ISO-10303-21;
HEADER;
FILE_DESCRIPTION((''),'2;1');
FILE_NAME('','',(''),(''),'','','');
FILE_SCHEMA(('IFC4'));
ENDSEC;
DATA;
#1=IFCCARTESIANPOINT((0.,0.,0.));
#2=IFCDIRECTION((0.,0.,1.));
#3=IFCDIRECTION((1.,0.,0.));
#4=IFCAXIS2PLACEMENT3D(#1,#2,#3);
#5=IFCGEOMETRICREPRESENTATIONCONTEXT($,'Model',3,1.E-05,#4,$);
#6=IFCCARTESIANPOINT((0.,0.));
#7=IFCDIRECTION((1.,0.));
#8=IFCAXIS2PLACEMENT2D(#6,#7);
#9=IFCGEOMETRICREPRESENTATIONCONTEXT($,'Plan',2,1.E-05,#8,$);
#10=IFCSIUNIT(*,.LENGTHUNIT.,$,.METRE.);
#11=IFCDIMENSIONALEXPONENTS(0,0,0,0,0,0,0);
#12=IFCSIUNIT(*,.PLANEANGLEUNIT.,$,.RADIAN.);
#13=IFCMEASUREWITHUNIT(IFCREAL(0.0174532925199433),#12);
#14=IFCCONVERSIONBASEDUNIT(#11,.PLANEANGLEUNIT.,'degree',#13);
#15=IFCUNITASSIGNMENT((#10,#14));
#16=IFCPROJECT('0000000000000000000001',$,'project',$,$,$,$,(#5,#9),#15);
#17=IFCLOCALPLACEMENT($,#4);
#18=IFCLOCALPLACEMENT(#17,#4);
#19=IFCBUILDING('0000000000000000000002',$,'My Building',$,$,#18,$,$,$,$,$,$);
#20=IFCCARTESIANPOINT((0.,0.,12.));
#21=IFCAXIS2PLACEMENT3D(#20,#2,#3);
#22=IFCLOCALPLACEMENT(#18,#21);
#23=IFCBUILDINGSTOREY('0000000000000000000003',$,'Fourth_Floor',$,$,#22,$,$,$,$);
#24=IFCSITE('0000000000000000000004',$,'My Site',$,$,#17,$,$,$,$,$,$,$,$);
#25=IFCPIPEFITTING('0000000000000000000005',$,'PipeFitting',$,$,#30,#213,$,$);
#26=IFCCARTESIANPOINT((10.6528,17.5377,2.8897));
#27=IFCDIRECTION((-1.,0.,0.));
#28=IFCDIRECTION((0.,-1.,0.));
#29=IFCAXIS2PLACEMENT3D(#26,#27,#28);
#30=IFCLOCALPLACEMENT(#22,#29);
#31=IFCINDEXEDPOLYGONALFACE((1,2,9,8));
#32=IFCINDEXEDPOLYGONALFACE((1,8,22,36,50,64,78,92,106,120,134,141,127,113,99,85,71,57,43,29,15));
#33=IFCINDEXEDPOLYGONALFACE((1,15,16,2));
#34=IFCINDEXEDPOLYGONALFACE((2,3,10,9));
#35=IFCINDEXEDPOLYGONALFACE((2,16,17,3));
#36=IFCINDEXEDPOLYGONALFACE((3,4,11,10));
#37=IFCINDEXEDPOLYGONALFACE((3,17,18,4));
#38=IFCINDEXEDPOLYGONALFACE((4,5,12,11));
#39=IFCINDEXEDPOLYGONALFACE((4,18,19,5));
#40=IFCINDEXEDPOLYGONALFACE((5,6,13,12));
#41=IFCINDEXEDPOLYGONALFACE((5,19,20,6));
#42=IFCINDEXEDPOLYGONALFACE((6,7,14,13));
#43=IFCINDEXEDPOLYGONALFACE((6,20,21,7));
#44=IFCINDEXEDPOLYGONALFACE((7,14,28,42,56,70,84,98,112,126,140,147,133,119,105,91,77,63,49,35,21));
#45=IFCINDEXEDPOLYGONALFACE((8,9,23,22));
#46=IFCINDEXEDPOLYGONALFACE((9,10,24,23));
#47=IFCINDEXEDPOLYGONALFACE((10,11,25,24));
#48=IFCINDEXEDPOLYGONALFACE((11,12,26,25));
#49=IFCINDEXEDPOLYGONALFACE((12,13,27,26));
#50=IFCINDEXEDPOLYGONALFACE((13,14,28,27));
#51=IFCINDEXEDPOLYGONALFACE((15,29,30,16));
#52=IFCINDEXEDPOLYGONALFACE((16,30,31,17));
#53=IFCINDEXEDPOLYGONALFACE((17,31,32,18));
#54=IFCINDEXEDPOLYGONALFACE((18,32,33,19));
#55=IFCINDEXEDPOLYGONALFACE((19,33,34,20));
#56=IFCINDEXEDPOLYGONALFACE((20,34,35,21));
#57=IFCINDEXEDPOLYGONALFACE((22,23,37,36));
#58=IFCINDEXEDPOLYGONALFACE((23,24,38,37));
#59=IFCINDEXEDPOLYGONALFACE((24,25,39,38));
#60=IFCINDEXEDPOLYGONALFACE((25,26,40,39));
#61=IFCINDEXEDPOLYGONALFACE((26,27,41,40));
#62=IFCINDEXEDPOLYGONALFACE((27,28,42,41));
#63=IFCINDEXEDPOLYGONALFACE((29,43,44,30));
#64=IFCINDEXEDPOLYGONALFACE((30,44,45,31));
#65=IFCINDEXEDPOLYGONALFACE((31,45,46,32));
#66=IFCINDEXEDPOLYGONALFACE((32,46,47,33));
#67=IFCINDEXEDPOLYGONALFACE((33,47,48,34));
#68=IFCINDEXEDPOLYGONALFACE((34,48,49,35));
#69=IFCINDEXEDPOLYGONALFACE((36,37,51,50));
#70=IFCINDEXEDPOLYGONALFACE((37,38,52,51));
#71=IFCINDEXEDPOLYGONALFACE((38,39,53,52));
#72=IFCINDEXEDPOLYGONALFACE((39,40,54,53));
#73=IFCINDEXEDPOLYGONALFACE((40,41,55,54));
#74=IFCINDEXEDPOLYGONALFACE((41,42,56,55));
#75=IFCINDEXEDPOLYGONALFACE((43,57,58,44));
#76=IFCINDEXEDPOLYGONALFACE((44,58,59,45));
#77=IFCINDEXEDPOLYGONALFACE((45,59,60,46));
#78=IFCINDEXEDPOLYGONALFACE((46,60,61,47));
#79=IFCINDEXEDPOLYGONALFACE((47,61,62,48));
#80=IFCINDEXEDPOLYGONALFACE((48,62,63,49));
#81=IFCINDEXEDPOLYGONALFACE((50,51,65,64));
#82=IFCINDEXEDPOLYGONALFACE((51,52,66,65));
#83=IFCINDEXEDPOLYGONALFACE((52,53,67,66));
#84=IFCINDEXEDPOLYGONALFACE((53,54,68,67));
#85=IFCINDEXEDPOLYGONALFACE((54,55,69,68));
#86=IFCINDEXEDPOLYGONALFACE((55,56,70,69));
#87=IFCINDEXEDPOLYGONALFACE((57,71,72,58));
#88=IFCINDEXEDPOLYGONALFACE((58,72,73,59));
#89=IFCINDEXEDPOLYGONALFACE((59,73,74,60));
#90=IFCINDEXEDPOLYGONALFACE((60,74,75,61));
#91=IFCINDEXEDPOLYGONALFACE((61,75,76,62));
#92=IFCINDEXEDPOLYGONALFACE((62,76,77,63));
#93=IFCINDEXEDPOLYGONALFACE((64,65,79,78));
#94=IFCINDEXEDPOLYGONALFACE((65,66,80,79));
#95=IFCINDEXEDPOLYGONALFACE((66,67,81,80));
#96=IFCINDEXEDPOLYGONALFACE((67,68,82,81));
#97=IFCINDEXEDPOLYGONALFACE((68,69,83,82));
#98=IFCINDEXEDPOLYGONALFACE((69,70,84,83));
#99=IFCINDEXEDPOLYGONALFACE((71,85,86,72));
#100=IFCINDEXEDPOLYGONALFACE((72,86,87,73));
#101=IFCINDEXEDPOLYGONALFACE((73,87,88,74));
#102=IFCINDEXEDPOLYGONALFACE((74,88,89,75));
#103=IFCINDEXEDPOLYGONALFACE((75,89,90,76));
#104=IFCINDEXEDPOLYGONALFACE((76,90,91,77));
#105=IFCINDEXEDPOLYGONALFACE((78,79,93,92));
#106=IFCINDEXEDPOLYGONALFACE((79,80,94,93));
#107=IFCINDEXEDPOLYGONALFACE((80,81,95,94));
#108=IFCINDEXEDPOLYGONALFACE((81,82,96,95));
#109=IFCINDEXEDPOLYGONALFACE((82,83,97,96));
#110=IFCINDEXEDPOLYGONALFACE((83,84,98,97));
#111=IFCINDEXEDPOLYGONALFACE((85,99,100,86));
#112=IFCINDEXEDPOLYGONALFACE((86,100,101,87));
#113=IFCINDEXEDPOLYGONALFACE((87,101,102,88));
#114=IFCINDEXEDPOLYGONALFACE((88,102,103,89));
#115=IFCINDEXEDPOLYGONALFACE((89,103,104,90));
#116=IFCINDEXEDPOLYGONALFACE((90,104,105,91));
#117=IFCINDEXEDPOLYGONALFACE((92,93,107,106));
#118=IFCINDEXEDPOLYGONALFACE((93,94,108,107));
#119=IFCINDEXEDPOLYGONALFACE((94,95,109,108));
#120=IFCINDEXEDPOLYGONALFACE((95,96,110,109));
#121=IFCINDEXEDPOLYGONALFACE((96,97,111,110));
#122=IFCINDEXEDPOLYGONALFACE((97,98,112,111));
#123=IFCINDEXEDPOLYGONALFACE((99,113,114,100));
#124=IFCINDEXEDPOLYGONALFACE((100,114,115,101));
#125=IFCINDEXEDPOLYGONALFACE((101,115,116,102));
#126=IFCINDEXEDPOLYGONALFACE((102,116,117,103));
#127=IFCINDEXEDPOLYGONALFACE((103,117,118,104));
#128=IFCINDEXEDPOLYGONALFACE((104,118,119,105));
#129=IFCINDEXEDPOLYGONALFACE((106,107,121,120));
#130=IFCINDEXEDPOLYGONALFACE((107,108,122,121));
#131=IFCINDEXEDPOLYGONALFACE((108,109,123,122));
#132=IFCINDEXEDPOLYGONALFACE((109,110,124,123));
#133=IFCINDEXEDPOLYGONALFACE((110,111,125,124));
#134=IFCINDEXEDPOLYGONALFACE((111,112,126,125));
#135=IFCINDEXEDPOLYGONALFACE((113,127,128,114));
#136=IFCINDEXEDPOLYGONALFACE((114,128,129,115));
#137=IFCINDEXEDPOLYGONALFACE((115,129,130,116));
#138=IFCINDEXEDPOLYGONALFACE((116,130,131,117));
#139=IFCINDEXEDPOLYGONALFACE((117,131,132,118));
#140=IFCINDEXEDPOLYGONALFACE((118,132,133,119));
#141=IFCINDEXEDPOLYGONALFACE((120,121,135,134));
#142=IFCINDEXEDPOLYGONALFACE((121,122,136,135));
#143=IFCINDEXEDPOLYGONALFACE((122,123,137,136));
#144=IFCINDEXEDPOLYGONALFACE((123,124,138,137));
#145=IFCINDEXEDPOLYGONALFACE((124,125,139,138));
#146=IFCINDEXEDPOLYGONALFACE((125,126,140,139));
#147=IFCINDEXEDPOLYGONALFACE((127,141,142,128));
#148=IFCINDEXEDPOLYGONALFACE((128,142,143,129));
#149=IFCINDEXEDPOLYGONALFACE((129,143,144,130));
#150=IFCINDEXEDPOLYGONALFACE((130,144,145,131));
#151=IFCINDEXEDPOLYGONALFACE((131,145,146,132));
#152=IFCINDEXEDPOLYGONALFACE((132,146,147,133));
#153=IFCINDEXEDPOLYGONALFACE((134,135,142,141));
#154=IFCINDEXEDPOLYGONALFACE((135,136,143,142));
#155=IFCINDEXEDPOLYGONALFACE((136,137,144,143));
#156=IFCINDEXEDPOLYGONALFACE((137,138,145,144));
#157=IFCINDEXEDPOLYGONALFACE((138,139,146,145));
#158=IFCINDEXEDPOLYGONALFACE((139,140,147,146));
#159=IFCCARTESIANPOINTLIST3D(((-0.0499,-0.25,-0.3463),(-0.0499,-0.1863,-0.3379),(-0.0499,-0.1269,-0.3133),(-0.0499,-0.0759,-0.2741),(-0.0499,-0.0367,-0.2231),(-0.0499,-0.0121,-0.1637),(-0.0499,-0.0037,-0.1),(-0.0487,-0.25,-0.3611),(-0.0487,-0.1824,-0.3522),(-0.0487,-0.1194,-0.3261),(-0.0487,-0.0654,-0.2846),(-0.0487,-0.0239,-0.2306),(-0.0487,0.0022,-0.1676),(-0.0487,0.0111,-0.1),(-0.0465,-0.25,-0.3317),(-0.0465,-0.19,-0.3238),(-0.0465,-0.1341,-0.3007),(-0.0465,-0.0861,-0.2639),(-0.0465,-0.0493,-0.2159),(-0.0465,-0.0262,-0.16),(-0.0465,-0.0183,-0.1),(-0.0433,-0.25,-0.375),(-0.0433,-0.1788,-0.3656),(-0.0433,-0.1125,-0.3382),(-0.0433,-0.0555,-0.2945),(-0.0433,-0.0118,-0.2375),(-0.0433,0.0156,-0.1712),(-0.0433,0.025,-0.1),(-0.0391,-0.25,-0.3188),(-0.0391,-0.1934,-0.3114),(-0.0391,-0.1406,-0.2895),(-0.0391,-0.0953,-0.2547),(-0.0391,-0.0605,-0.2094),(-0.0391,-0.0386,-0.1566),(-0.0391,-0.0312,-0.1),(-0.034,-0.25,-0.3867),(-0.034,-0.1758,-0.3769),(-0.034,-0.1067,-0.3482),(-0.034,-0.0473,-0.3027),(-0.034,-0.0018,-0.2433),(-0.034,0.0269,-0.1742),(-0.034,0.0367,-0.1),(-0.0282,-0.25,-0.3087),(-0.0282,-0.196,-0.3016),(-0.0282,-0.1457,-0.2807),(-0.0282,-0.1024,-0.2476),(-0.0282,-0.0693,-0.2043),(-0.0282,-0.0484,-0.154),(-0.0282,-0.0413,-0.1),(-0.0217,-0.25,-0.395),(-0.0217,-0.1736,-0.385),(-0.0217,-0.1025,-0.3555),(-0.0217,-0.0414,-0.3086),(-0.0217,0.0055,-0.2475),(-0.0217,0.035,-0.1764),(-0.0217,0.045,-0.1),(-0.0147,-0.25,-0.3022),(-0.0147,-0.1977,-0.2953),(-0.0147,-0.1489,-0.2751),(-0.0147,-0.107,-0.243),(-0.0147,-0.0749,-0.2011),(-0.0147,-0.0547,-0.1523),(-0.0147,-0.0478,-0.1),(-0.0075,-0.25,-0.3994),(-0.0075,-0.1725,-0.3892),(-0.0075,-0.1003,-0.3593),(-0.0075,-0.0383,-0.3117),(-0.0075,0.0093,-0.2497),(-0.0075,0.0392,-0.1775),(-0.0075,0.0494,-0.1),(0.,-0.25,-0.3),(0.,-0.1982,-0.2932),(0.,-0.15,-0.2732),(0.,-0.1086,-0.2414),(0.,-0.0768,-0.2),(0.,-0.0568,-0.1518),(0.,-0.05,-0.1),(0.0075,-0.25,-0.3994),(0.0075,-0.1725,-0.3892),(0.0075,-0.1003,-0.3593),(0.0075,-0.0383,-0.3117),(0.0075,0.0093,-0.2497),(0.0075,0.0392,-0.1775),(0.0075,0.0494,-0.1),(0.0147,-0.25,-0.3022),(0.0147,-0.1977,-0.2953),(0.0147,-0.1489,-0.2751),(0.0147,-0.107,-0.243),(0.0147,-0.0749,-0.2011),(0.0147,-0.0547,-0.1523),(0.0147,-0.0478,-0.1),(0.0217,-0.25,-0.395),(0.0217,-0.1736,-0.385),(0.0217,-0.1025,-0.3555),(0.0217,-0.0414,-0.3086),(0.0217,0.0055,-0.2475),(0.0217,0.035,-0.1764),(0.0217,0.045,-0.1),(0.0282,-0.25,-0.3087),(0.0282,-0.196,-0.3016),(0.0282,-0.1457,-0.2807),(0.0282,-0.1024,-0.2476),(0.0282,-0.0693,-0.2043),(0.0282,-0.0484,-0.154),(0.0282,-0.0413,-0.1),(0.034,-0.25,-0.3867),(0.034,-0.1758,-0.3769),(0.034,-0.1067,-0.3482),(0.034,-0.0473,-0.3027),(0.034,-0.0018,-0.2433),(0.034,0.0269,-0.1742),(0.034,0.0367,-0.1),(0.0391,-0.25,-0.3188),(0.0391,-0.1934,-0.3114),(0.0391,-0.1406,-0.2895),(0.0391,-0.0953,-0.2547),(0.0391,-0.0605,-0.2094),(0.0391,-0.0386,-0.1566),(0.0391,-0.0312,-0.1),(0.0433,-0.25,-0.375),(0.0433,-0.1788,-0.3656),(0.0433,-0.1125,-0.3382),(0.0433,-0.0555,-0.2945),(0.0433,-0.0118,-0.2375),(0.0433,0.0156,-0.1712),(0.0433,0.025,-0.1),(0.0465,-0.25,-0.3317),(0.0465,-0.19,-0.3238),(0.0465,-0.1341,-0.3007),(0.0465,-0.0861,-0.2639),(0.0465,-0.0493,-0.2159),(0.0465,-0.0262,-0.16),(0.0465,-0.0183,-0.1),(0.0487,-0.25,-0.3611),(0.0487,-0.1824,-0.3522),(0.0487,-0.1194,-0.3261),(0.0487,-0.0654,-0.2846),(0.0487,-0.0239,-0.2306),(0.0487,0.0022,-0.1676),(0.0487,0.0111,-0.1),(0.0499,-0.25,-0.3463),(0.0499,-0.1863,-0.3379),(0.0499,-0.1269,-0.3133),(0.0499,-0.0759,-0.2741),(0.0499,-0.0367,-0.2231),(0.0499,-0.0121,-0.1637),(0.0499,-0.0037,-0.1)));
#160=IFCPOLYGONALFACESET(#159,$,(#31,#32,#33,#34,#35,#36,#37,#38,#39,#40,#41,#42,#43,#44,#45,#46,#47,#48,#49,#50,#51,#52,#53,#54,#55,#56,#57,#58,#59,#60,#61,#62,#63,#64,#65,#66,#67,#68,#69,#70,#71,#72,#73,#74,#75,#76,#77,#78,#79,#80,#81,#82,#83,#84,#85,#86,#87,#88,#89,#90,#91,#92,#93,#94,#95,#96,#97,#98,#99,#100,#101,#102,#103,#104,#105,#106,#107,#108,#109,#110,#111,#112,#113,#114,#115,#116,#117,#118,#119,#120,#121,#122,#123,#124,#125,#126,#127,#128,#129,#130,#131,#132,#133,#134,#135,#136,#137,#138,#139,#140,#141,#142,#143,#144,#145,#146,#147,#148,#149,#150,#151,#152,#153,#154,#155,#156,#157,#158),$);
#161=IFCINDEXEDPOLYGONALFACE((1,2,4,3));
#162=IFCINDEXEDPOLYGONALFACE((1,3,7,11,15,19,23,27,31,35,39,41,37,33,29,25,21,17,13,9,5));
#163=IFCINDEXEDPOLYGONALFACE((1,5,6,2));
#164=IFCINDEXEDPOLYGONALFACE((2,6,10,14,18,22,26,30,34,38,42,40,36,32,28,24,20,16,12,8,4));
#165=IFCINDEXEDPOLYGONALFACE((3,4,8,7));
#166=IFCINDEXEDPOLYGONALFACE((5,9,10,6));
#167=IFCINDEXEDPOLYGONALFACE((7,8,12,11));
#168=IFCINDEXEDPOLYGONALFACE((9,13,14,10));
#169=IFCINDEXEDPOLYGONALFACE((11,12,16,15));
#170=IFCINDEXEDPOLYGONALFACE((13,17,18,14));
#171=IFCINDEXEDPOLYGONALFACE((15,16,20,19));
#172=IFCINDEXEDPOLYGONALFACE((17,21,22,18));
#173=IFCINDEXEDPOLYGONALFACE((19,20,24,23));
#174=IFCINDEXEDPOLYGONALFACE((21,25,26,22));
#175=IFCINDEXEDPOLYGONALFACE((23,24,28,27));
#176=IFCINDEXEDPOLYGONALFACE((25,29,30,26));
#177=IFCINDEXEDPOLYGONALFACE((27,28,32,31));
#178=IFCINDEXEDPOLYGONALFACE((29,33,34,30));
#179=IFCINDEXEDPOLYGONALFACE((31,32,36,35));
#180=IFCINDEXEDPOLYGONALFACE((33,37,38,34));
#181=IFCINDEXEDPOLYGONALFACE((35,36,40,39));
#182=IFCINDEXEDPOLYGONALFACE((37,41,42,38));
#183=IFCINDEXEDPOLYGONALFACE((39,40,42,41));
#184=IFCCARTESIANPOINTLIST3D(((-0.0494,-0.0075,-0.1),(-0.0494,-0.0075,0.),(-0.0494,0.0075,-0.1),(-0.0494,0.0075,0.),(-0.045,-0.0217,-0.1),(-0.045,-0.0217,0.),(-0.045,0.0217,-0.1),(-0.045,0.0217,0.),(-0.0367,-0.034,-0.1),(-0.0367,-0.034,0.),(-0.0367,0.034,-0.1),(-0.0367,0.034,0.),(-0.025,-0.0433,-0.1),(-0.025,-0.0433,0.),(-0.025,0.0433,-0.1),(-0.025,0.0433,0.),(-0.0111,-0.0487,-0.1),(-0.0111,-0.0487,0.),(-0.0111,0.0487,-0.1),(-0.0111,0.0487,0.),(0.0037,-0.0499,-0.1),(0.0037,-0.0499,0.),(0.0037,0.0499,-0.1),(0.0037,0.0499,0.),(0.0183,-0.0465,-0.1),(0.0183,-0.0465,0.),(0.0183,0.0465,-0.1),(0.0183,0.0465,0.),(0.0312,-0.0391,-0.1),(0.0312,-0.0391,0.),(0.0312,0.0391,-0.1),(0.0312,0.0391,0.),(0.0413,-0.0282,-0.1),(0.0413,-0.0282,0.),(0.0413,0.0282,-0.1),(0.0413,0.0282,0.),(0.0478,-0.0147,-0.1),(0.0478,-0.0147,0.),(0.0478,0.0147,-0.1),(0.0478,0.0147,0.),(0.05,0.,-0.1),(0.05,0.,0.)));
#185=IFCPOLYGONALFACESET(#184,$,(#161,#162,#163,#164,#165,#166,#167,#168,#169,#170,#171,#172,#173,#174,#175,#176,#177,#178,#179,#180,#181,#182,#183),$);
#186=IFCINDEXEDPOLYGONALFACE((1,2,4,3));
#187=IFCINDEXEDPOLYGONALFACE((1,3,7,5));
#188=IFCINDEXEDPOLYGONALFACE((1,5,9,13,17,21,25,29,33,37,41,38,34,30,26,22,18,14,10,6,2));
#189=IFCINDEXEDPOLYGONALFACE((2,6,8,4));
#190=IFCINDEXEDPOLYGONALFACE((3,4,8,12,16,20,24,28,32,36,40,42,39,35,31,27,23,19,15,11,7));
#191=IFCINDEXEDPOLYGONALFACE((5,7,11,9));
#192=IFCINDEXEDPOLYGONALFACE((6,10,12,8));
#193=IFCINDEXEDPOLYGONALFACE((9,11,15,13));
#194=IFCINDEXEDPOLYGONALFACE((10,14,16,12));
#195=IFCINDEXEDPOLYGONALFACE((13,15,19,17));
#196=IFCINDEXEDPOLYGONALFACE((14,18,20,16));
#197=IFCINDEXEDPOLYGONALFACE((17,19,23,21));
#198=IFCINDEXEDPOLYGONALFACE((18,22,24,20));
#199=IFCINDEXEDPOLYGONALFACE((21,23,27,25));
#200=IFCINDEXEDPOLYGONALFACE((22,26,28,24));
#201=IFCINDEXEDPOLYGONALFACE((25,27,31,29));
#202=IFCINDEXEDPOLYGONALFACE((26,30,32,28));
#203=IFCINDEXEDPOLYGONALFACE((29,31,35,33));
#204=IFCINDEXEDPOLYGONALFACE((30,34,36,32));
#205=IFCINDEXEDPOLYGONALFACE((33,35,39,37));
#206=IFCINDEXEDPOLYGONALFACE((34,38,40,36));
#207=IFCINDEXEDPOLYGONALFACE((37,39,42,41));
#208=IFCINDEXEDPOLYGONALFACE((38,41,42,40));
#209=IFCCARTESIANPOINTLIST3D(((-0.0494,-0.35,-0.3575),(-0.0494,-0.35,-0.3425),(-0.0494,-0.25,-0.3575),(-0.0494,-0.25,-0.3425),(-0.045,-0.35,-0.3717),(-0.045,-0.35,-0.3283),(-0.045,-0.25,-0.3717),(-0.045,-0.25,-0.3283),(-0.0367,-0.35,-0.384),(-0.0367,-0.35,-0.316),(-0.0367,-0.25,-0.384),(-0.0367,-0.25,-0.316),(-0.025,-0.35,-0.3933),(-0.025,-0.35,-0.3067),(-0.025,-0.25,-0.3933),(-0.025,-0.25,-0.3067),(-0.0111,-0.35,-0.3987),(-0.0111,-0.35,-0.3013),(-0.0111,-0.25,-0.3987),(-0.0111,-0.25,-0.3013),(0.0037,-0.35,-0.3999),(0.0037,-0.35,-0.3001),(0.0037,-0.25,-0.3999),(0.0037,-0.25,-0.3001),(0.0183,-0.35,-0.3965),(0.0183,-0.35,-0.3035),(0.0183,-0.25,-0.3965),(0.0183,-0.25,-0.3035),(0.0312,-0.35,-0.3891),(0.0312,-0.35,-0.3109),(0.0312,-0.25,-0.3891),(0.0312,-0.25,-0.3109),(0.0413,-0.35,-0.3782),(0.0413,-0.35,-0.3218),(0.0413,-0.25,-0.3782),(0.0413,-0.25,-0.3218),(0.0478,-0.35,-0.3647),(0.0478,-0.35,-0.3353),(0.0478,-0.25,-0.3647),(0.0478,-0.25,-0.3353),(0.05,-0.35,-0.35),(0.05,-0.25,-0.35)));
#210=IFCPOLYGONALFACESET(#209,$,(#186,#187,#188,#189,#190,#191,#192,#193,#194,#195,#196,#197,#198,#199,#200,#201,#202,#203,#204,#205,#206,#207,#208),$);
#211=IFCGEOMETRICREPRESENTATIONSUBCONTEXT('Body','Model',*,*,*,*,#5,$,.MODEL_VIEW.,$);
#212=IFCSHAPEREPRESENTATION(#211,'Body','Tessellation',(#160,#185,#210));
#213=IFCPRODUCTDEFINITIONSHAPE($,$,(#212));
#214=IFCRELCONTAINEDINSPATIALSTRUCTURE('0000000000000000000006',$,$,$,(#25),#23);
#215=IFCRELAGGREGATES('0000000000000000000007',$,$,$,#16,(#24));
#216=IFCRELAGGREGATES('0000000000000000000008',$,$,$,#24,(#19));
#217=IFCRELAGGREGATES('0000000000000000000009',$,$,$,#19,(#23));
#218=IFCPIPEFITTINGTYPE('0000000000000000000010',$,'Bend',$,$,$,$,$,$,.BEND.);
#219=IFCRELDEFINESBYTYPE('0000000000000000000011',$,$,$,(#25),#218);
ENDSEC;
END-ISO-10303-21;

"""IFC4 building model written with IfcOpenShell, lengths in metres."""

from ifc_helpers import new_model, entity, si_unit, converted_unit, frame, origin_with_axes, origin_2d_with_axis, place, context, subcontext, project, spatial, circle, extrude, source, transform, mapped, type_object, type_shapes, element, save


model = new_model("IFC4")

# Units and contexts
model_context = context("Model", 3, precision=1e-05, world=origin_with_axes())
plan_context = context("Plan", 2, precision=1e-05, world=origin_2d_with_axis())
body_context_1 = subcontext(model_context, "Body", "Model", "MODEL_VIEW")
ifc_project = project(units=[si_unit("LENGTHUNIT", "METRE"), converted_unit("PLANEANGLEUNIT", "degree", entity("IfcReal", 0.0174532925199433), si_unit("PLANEANGLEUNIT", "RADIAN"), dimensions=[0, 0, 0, 0, 0, 0, 0])], contexts=[model_context, plan_context])

# Site, building, storey
site_placement = place(None, origin_with_axes())
site = spatial("IfcSite", under=ifc_project, at=site_placement, Name="My Site")
building_placement = place(site_placement, origin_with_axes())
building = spatial("IfcBuilding", under=site, at=building_placement, Name="My Building")
storey_placement = place(building_placement, frame((0.0, 0.0, 12.0), z_axis=(0.0, 0.0, 1.0), x_axis=(1.0, 0.0, 0.0)))
storey = spatial("IfcBuildingStorey", under=building, at=storey_placement, Name="Fourth_Floor")

# Pipe fitting
pipe_fitting_type = type_object("IfcPipeFittingType", Name="Bend", PredefinedType="BEND")
shared_shape_1 = source(origin_with_axes(), body_context_1, "Body", "SolidModel", [
    entity("IfcSweptDiskSolid", entity("IfcIndexedPolyCurve", entity("IfcCartesianPointList3D", [[0.0, 0.0, -0.1], [0.0, -0.0732, -0.2768], [0.0, -0.25, -0.35]]), [entity("IfcArcIndex", [1, 2, 3])]), 0.05),
    extrude(circle(Radius=0.05), origin_with_axes(), (0.0, 0.0, -1.0), 0.1),
    extrude(circle(Radius=0.05), frame((0.0, -0.25, -0.35), z_axis=(0.0, -1.0, 0.0), x_axis=(1.0, 0.0, 0.0)), (0.0, 0.0, 1.0), 0.1),
])
type_shapes(pipe_fitting_type, [shared_shape_1])
for number, where, z_axis, x_axis, name in (
    (1, (10.6528, 17.5377, 2.8897), (-1.0, 0.0, 0.0), (0.0, -1.0, 0.0), "PipeFitting"),
):
    element("IfcPipeFitting", number, at=place(storey_placement, frame(where, z_axis=z_axis, x_axis=x_axis)), inside=storey, type_object=pipe_fitting_type, Name=name, context=body_context_1, shape_type="MappedRepresentation", body=[
        mapped(shared_shape_1, transform((0.0, 0.0, 0.0), x_axis=(1.0, 0.0, 0.0), y_axis=(0.0, 1.0, 0.0), z_axis=(0.0, 0.0, 1.0), scale=1.0)),
    ])

save(model, "model.ifc")
